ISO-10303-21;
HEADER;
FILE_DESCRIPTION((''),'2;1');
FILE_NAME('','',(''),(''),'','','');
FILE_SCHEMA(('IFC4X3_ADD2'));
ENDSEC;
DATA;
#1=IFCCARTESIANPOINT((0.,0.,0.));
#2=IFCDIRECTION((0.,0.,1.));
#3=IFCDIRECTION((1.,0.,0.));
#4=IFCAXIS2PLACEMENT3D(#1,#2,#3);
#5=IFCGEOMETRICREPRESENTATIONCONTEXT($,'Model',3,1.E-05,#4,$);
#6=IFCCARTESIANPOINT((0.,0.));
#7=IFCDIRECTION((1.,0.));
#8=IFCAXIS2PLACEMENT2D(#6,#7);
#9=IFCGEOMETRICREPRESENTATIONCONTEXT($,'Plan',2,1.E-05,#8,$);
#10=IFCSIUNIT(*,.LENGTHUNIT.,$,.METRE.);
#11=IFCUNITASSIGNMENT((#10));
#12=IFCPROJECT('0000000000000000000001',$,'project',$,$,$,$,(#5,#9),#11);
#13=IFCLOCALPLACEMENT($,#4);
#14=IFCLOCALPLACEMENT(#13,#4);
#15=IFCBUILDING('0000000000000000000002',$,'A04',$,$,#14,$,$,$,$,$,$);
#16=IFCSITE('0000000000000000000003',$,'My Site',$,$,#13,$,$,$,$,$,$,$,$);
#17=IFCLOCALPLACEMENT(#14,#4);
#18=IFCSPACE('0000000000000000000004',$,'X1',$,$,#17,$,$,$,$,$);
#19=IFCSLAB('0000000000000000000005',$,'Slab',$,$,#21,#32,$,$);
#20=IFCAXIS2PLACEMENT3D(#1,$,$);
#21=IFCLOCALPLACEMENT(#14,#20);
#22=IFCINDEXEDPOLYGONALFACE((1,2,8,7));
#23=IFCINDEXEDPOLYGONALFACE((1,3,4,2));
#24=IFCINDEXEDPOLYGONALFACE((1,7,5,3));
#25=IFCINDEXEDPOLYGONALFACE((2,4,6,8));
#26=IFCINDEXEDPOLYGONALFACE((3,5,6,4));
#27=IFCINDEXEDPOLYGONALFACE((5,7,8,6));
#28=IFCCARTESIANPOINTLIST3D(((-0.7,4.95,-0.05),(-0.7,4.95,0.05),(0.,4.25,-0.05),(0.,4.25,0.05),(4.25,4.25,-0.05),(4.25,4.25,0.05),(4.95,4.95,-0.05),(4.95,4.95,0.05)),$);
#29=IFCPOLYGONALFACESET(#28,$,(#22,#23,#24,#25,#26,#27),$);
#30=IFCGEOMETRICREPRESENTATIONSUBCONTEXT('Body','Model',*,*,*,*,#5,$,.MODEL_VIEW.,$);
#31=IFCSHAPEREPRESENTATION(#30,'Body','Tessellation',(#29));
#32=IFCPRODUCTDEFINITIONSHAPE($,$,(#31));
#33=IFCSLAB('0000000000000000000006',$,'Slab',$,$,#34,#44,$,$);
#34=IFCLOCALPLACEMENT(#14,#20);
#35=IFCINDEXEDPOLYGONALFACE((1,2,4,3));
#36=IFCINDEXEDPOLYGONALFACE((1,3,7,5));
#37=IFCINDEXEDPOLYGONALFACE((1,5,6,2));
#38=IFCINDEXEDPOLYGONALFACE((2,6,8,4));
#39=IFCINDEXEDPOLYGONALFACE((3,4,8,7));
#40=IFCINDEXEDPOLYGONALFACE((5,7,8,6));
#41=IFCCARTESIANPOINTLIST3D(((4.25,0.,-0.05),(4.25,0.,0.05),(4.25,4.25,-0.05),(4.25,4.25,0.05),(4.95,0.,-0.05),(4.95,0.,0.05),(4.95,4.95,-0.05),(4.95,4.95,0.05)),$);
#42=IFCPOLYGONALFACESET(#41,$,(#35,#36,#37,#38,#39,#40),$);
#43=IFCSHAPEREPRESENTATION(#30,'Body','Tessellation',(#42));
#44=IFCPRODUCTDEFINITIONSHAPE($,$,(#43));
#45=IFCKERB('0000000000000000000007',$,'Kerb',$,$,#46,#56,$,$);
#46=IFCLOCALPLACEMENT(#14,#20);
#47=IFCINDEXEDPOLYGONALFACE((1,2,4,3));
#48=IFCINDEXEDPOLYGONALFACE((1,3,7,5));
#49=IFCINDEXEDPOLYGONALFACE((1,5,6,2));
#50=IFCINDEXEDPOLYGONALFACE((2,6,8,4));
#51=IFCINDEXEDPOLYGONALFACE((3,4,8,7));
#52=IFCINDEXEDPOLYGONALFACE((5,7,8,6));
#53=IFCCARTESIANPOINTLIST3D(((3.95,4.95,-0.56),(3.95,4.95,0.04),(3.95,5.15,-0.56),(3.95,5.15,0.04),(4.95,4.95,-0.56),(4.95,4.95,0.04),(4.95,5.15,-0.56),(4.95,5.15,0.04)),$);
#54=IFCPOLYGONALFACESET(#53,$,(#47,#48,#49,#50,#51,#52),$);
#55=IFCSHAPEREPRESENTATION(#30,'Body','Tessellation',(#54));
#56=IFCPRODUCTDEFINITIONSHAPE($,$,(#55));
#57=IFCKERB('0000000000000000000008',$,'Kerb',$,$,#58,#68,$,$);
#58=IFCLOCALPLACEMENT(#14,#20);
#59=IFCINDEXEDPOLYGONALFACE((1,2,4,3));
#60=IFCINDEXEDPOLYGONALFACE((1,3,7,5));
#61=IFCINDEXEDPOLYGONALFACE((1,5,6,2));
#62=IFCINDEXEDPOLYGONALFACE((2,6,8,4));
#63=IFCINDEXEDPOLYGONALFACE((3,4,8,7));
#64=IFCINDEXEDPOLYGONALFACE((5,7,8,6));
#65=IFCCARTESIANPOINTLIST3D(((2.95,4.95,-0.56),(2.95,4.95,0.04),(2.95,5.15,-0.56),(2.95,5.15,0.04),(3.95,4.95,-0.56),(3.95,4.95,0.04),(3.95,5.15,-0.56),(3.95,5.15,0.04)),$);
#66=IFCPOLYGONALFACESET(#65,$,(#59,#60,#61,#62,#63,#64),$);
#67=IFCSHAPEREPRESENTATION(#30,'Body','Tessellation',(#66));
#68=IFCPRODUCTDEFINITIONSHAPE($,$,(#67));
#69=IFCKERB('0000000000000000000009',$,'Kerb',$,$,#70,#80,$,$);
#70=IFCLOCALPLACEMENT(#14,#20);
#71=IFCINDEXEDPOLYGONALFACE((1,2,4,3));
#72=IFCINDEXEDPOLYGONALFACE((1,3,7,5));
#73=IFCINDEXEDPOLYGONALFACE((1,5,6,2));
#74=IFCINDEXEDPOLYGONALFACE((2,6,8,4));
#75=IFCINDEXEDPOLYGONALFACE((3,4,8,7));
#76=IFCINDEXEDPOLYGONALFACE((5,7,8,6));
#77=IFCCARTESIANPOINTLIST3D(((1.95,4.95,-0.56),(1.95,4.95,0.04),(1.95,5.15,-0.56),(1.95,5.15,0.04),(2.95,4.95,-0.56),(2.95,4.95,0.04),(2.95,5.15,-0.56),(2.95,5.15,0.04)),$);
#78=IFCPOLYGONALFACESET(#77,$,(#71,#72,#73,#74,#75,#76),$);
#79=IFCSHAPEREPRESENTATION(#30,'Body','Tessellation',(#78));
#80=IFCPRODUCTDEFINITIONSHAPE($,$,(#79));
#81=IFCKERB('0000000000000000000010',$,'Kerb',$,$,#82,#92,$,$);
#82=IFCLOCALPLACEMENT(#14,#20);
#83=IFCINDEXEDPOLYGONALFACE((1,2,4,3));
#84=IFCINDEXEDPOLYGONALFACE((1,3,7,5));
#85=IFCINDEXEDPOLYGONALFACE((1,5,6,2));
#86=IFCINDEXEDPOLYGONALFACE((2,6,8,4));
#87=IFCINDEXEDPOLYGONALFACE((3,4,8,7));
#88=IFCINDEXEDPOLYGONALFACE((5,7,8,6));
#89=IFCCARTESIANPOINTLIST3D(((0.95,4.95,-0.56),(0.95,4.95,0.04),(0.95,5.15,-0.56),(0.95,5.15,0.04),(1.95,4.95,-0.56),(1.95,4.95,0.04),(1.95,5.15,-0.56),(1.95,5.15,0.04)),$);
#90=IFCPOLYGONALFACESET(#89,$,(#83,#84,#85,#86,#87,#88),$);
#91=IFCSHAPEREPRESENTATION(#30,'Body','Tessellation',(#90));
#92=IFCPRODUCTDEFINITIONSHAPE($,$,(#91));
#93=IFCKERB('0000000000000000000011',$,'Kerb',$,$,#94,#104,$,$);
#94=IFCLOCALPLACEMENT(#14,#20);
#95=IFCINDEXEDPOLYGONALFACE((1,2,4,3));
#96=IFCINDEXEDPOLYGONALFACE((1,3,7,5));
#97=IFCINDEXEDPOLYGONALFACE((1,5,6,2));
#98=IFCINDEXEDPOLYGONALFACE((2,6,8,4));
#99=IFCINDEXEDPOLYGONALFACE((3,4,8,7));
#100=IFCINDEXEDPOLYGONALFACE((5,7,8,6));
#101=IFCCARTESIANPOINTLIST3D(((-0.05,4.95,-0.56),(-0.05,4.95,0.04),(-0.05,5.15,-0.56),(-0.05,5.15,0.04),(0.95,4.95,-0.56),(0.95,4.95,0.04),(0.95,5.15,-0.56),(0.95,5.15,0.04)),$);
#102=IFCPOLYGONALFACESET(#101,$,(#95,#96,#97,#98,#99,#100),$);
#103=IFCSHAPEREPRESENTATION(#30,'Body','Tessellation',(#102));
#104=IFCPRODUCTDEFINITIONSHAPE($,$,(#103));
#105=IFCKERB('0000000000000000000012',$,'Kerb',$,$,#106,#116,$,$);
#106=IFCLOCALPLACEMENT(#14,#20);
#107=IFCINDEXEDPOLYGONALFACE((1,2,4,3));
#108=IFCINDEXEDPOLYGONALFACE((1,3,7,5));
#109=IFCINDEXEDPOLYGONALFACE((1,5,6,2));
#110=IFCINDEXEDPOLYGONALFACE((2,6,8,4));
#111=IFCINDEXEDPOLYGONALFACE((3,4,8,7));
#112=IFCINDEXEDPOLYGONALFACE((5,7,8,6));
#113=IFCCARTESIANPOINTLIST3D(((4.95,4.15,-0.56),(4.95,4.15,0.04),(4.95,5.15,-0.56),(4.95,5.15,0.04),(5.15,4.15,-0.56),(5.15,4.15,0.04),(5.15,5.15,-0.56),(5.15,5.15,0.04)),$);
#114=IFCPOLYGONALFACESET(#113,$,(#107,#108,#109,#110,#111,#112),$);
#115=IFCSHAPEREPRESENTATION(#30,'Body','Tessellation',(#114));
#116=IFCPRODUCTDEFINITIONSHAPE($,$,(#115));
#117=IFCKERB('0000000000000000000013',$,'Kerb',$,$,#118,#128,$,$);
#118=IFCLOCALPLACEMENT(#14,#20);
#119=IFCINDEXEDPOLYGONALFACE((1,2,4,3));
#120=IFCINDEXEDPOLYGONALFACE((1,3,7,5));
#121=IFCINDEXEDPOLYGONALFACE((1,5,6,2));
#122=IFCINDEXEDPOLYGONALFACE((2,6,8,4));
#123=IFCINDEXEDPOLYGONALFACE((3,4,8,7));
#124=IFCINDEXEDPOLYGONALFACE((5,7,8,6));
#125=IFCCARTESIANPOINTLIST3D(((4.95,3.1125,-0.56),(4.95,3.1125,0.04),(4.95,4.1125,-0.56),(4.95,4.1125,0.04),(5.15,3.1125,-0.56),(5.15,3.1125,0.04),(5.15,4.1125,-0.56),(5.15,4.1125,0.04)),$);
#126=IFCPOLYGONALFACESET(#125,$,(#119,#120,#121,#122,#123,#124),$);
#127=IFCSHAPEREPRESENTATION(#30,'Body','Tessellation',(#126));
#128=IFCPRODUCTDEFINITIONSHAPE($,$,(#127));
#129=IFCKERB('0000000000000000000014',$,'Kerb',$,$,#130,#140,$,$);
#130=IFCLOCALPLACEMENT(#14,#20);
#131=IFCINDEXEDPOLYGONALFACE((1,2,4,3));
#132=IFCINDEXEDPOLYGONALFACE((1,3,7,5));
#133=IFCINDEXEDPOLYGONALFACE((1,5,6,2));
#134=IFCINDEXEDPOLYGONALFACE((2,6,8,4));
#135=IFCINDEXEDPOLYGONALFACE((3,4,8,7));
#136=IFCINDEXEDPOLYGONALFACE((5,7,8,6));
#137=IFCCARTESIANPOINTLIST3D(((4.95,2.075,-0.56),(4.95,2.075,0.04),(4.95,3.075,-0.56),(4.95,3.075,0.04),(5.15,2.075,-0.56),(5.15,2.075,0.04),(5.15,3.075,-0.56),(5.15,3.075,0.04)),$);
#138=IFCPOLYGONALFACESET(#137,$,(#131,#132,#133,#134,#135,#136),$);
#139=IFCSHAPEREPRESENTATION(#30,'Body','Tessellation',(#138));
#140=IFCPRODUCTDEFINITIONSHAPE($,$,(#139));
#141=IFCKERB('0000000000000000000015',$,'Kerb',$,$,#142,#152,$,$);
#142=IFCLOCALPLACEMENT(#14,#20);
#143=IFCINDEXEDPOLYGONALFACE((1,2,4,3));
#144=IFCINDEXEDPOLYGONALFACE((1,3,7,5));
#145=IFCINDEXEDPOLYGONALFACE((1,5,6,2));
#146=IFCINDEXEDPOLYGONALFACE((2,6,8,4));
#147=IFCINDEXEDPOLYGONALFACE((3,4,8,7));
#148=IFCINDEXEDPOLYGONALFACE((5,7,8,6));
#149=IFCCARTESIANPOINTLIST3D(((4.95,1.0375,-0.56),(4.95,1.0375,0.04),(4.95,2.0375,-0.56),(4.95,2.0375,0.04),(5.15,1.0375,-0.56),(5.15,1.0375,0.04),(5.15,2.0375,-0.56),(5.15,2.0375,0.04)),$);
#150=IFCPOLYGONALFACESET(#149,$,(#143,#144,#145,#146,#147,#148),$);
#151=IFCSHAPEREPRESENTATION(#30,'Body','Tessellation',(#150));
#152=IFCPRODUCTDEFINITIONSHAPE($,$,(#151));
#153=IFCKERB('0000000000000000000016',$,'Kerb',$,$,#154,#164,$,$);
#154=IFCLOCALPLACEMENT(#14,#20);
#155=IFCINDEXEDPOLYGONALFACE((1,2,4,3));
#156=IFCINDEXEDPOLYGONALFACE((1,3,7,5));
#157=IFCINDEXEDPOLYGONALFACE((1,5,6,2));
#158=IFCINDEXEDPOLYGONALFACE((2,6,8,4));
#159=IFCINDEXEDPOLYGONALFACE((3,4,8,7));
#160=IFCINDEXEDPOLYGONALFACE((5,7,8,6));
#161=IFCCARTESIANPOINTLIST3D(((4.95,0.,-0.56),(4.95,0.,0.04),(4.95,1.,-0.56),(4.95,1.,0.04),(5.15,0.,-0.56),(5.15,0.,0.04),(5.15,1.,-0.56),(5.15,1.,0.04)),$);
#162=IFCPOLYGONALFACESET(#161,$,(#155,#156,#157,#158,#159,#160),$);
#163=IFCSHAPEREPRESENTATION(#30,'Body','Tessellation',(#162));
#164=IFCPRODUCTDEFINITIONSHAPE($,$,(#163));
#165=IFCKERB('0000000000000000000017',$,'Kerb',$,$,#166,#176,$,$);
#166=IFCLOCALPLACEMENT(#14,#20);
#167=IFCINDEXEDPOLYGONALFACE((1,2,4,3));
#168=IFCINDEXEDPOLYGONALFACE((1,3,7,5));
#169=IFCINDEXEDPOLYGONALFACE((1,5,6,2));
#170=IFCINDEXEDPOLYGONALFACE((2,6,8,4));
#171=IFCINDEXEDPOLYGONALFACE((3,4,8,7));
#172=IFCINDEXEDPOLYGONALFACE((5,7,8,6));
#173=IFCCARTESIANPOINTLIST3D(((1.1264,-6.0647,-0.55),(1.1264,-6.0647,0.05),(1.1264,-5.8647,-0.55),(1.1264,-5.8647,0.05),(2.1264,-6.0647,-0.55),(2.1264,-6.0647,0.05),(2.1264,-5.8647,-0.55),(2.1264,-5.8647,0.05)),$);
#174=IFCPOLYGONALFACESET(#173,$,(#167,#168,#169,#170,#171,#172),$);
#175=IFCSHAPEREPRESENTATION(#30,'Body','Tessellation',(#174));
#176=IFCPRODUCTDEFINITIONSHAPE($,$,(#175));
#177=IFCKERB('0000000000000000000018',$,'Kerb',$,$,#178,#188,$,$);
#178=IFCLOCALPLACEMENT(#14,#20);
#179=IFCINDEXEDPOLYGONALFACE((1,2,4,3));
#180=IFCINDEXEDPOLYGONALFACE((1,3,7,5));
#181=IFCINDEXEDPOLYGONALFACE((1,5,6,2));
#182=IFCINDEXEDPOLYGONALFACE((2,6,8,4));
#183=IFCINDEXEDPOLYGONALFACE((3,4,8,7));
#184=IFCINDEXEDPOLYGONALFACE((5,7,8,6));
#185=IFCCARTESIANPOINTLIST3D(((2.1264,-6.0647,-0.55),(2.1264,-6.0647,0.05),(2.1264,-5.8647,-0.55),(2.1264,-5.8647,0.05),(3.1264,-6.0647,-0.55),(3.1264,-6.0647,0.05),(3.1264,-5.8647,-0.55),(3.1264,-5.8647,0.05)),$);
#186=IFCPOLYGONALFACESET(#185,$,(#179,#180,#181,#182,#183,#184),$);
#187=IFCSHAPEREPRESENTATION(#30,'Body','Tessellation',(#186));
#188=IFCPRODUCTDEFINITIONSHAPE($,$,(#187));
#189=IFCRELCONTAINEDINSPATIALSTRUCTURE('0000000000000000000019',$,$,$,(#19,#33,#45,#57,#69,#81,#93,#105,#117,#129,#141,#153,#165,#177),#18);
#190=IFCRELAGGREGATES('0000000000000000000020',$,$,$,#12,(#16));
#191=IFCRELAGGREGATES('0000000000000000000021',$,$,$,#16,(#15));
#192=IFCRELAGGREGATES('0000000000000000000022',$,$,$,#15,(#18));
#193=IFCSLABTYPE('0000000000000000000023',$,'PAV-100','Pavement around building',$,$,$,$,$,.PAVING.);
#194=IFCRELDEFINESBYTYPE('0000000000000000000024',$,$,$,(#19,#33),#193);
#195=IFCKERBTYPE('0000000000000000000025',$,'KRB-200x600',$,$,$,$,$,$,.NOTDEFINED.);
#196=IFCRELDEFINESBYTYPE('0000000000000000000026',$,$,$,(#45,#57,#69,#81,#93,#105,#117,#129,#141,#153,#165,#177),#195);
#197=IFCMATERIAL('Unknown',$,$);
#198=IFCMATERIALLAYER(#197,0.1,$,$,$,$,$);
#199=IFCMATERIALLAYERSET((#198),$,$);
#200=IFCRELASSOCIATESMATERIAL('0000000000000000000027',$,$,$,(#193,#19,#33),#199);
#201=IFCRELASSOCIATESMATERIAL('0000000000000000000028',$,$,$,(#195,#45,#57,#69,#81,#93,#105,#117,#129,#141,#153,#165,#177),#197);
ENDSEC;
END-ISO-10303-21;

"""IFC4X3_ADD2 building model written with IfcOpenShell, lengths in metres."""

from ifc_helpers import new_model, si_unit, frame, origin_with_axes, origin_2d_with_axis, place, context, subcontext, project, spatial, indexed_curve, rectangle, outline, extrude, material, layer, layer_set, layer_usage, material_profile, profile_set, profile_usage, type_object, element, save


model = new_model("IFC4X3_ADD2")

# Units and contexts
model_context = context("Model", 3, precision=1e-05, world=origin_with_axes())
plan_context = context("Plan", 2, precision=1e-05, world=origin_2d_with_axis())
body_context = subcontext(model_context, "Body", "Model", "MODEL_VIEW")
ifc_project = project(units=[si_unit("LENGTHUNIT", "METRE")], contexts=[model_context, plan_context])

# Site, building, space
site_placement = place(None, origin_with_axes())
site = spatial("IfcSite", under=ifc_project, at=site_placement, Name="My Site")
building_placement = place(site_placement, origin_with_axes())
building = spatial("IfcBuilding", under=site, at=building_placement, Name="A04")
space_placement = place(building_placement, origin_with_axes())
space = spatial("IfcSpace", under=building, at=space_placement, Name="X1")

# Slabs
ifc_material = material(Name="Unknown")
ifc_layer = layer(ifc_material, 0.1)
ifc_layer_set = layer_set([ifc_layer])
ifc_layer_usage_1 = layer_usage(ifc_layer_set, "AXIS3", "POSITIVE", -0.1)
slab_type = type_object("IfcSlabType", Name="PAV-100", Description="Pavement around building", PredefinedType="PAVING", material=ifc_layer_set)
slab_1_placement = place(space_placement, frame((4.95, 4.95, 0.05), z_axis=(0.0, 0.0, 1.0), x_axis=(1.0, 0.0, 0.0)))
element("IfcSlab", 1, at=slab_1_placement, inside=space, type_object=slab_type, material=ifc_layer_usage_1, Name="Slab", context=body_context, shape_type="SweptSolid", body=[
    extrude(outline(indexed_curve([(-5.65, 0.0), (-4.95, -0.7), (-0.7, -0.7), (0.0, 0.0), (-5.65, 0.0)])), frame((0.0, 0.0, -0.1), z_axis=(0.0, 0.0, 1.0), x_axis=(1.0, 0.0, 0.0)), (0.0, 0.0, 1.0), 0.1),
])
ifc_layer_usage_2 = layer_usage(ifc_layer_set, "AXIS3", "POSITIVE", -0.1)
slab_2_placement = place(space_placement, frame((4.95, 0.0, 0.05), z_axis=(0.0, 0.0, 1.0), x_axis=(0.0, -1.0, 0.0)))
element("IfcSlab", 2, at=slab_2_placement, inside=space, type_object=slab_type, material=ifc_layer_usage_2, Name="Slab", context=body_context, shape_type="SweptSolid", body=[
    extrude(outline(indexed_curve([(-4.95, 0.0), (-4.25, -0.7), (0.0, -0.7), (0.0, 0.0), (-4.95, 0.0)])), frame((0.0, 0.0, -0.1), z_axis=(0.0, 0.0, 1.0), x_axis=(1.0, 0.0, 0.0)), (0.0, 0.0, 1.0), 0.1),
])

# Kerbs
ifc_material_profile = material_profile(ifc_material, rectangle(XDim=0.2, YDim=0.6))
ifc_profile_set = profile_set([ifc_material_profile])
ifc_profile_usage_1 = profile_usage(ifc_profile_set, cardinal=2)
kerb_type = type_object("IfcKerbType", Name="KRB-200x600", PredefinedType="NOTDEFINED", material=ifc_profile_set)
kerb_1_placement = place(space_placement, frame((4.95, 5.05, -0.56), z_axis=(-1.0, 0.0, 0.0), x_axis=(0.0, -1.0, 0.0)))
element("IfcKerb", 3, at=kerb_1_placement, inside=space, type_object=kerb_type, material=ifc_profile_usage_1, Name="Kerb", context=body_context, shape_type="SweptSolid", body=[
    extrude(rectangle(XDim=0.2, YDim=0.6), frame((0.0, 0.3, 0.0), z_axis=(0.0, 0.0, 1.0), x_axis=(1.0, 0.0, 0.0)), (0.0, 0.0, 1.0), 1.0),
])
ifc_profile_usage_2 = profile_usage(ifc_profile_set, cardinal=2)
kerb_2_placement = place(space_placement, frame((3.95, 5.05, -0.56), z_axis=(-1.0, 0.0, 0.0), x_axis=(0.0, -1.0, 0.0)))
element("IfcKerb", 4, at=kerb_2_placement, inside=space, type_object=kerb_type, material=ifc_profile_usage_2, Name="Kerb", context=body_context, shape_type="SweptSolid", body=[
    extrude(rectangle(XDim=0.2, YDim=0.6), frame((0.0, 0.3, 0.0), z_axis=(0.0, 0.0, 1.0), x_axis=(1.0, 0.0, 0.0)), (0.0, 0.0, 1.0), 1.0),
])
ifc_profile_usage_3 = profile_usage(ifc_profile_set, cardinal=2)
kerb_3_placement = place(space_placement, frame((2.95, 5.05, -0.56), z_axis=(-1.0, 0.0, 0.0), x_axis=(0.0, -1.0, 0.0)))
element("IfcKerb", 5, at=kerb_3_placement, inside=space, type_object=kerb_type, material=ifc_profile_usage_3, Name="Kerb", context=body_context, shape_type="SweptSolid", body=[
    extrude(rectangle(XDim=0.2, YDim=0.6), frame((0.0, 0.3, 0.0), z_axis=(0.0, 0.0, 1.0), x_axis=(1.0, 0.0, 0.0)), (0.0, 0.0, 1.0), 1.0),
])
ifc_profile_usage_4 = profile_usage(ifc_profile_set, cardinal=2)
kerb_4_placement = place(space_placement, frame((1.95, 5.05, -0.56), z_axis=(-1.0, 0.0, 0.0), x_axis=(0.0, -1.0, 0.0)))
element("IfcKerb", 6, at=kerb_4_placement, inside=space, type_object=kerb_type, material=ifc_profile_usage_4, Name="Kerb", context=body_context, shape_type="SweptSolid", body=[
    extrude(rectangle(XDim=0.2, YDim=0.6), frame((0.0, 0.3, 0.0), z_axis=(0.0, 0.0, 1.0), x_axis=(1.0, 0.0, 0.0)), (0.0, 0.0, 1.0), 1.0),
])
ifc_profile_usage_5 = profile_usage(ifc_profile_set, cardinal=2)
kerb_5_placement = place(space_placement, frame((0.95, 5.05, -0.56), z_axis=(-1.0, 0.0, 0.0), x_axis=(0.0, -1.0, 0.0)))
element("IfcKerb", 7, at=kerb_5_placement, inside=space, type_object=kerb_type, material=ifc_profile_usage_5, Name="Kerb", context=body_context, shape_type="SweptSolid", body=[
    extrude(rectangle(XDim=0.2, YDim=0.6), frame((0.0, 0.3, 0.0), z_axis=(0.0, 0.0, 1.0), x_axis=(1.0, 0.0, 0.0)), (0.0, 0.0, 1.0), 1.0),
])
ifc_profile_usage_6 = profile_usage(ifc_profile_set, cardinal=2)
kerb_6_placement = place(space_placement, frame((5.05, 5.15, -0.56), z_axis=(0.0, -1.0, 0.0), x_axis=(1.0, 0.0, 0.0)))
element("IfcKerb", 8, at=kerb_6_placement, inside=space, type_object=kerb_type, material=ifc_profile_usage_6, Name="Kerb", context=body_context, shape_type="SweptSolid", body=[
    extrude(rectangle(XDim=0.2, YDim=0.6), frame((0.0, 0.3, 0.0), z_axis=(0.0, 0.0, 1.0), x_axis=(1.0, 0.0, 0.0)), (0.0, 0.0, 1.0), 1.0),
])
ifc_profile_usage_7 = profile_usage(ifc_profile_set, cardinal=2)
kerb_7_placement = place(space_placement, frame((5.05, 4.1125, -0.56), z_axis=(0.0, -1.0, 0.0), x_axis=(1.0, 0.0, 0.0)))
element("IfcKerb", 9, at=kerb_7_placement, inside=space, type_object=kerb_type, material=ifc_profile_usage_7, Name="Kerb", context=body_context, shape_type="SweptSolid", body=[
    extrude(rectangle(XDim=0.2, YDim=0.6), frame((0.0, 0.3, 0.0), z_axis=(0.0, 0.0, 1.0), x_axis=(1.0, 0.0, 0.0)), (0.0, 0.0, 1.0), 1.0),
])
ifc_profile_usage_8 = profile_usage(ifc_profile_set, cardinal=2)
kerb_8_placement = place(space_placement, frame((5.05, 3.075, -0.56), z_axis=(0.0, -1.0, 0.0), x_axis=(1.0, 0.0, 0.0)))
element("IfcKerb", 10, at=kerb_8_placement, inside=space, type_object=kerb_type, material=ifc_profile_usage_8, Name="Kerb", context=body_context, shape_type="SweptSolid", body=[
    extrude(rectangle(XDim=0.2, YDim=0.6), frame((0.0, 0.3, 0.0), z_axis=(0.0, 0.0, 1.0), x_axis=(1.0, 0.0, 0.0)), (0.0, 0.0, 1.0), 1.0),
])
ifc_profile_usage_9 = profile_usage(ifc_profile_set, cardinal=2)
kerb_9_placement = place(space_placement, frame((5.05, 2.0375, -0.56), z_axis=(0.0, -1.0, 0.0), x_axis=(1.0, 0.0, 0.0)))
element("IfcKerb", 11, at=kerb_9_placement, inside=space, type_object=kerb_type, material=ifc_profile_usage_9, Name="Kerb", context=body_context, shape_type="SweptSolid", body=[
    extrude(rectangle(XDim=0.2, YDim=0.6), frame((0.0, 0.3, 0.0), z_axis=(0.0, 0.0, 1.0), x_axis=(1.0, 0.0, 0.0)), (0.0, 0.0, 1.0), 1.0),
])
ifc_profile_usage_10 = profile_usage(ifc_profile_set, cardinal=2)
kerb_10_placement = place(space_placement, frame((5.05, 1.0, -0.56), z_axis=(0.0, -1.0, 0.0), x_axis=(1.0, 0.0, 0.0)))
element("IfcKerb", 12, at=kerb_10_placement, inside=space, type_object=kerb_type, material=ifc_profile_usage_10, Name="Kerb", context=body_context, shape_type="SweptSolid", body=[
    extrude(rectangle(XDim=0.2, YDim=0.6), frame((0.0, 0.3, 0.0), z_axis=(0.0, 0.0, 1.0), x_axis=(1.0, 0.0, 0.0)), (0.0, 0.0, 1.0), 1.0),
])
ifc_profile_usage_11 = profile_usage(ifc_profile_set, cardinal=2)
kerb_11_placement = place(space_placement, frame((1.1264, -5.9647, -0.55), z_axis=(1.0, 0.0, 0.0), x_axis=(0.0, 1.0, 0.0)))
element("IfcKerb", 13, at=kerb_11_placement, inside=space, type_object=kerb_type, material=ifc_profile_usage_11, Name="Kerb", context=body_context, shape_type="SweptSolid", body=[
    extrude(rectangle(XDim=0.2, YDim=0.6), frame((0.0, 0.3, 0.0), z_axis=(0.0, 0.0, 1.0), x_axis=(1.0, 0.0, 0.0)), (0.0, 0.0, 1.0), 1.0),
])
ifc_profile_usage_12 = profile_usage(ifc_profile_set, cardinal=2)
kerb_12_placement = place(space_placement, frame((2.1264, -5.9647, -0.55), z_axis=(1.0, 0.0, 0.0), x_axis=(0.0, 1.0, 0.0)))
element("IfcKerb", 14, at=kerb_12_placement, inside=space, type_object=kerb_type, material=ifc_profile_usage_12, Name="Kerb", context=body_context, shape_type="SweptSolid", body=[
    extrude(rectangle(XDim=0.2, YDim=0.6), frame((0.0, 0.3, 0.0), z_axis=(0.0, 0.0, 1.0), x_axis=(1.0, 0.0, 0.0)), (0.0, 0.0, 1.0), 1.0),
])

save(model, "model.ifc")
